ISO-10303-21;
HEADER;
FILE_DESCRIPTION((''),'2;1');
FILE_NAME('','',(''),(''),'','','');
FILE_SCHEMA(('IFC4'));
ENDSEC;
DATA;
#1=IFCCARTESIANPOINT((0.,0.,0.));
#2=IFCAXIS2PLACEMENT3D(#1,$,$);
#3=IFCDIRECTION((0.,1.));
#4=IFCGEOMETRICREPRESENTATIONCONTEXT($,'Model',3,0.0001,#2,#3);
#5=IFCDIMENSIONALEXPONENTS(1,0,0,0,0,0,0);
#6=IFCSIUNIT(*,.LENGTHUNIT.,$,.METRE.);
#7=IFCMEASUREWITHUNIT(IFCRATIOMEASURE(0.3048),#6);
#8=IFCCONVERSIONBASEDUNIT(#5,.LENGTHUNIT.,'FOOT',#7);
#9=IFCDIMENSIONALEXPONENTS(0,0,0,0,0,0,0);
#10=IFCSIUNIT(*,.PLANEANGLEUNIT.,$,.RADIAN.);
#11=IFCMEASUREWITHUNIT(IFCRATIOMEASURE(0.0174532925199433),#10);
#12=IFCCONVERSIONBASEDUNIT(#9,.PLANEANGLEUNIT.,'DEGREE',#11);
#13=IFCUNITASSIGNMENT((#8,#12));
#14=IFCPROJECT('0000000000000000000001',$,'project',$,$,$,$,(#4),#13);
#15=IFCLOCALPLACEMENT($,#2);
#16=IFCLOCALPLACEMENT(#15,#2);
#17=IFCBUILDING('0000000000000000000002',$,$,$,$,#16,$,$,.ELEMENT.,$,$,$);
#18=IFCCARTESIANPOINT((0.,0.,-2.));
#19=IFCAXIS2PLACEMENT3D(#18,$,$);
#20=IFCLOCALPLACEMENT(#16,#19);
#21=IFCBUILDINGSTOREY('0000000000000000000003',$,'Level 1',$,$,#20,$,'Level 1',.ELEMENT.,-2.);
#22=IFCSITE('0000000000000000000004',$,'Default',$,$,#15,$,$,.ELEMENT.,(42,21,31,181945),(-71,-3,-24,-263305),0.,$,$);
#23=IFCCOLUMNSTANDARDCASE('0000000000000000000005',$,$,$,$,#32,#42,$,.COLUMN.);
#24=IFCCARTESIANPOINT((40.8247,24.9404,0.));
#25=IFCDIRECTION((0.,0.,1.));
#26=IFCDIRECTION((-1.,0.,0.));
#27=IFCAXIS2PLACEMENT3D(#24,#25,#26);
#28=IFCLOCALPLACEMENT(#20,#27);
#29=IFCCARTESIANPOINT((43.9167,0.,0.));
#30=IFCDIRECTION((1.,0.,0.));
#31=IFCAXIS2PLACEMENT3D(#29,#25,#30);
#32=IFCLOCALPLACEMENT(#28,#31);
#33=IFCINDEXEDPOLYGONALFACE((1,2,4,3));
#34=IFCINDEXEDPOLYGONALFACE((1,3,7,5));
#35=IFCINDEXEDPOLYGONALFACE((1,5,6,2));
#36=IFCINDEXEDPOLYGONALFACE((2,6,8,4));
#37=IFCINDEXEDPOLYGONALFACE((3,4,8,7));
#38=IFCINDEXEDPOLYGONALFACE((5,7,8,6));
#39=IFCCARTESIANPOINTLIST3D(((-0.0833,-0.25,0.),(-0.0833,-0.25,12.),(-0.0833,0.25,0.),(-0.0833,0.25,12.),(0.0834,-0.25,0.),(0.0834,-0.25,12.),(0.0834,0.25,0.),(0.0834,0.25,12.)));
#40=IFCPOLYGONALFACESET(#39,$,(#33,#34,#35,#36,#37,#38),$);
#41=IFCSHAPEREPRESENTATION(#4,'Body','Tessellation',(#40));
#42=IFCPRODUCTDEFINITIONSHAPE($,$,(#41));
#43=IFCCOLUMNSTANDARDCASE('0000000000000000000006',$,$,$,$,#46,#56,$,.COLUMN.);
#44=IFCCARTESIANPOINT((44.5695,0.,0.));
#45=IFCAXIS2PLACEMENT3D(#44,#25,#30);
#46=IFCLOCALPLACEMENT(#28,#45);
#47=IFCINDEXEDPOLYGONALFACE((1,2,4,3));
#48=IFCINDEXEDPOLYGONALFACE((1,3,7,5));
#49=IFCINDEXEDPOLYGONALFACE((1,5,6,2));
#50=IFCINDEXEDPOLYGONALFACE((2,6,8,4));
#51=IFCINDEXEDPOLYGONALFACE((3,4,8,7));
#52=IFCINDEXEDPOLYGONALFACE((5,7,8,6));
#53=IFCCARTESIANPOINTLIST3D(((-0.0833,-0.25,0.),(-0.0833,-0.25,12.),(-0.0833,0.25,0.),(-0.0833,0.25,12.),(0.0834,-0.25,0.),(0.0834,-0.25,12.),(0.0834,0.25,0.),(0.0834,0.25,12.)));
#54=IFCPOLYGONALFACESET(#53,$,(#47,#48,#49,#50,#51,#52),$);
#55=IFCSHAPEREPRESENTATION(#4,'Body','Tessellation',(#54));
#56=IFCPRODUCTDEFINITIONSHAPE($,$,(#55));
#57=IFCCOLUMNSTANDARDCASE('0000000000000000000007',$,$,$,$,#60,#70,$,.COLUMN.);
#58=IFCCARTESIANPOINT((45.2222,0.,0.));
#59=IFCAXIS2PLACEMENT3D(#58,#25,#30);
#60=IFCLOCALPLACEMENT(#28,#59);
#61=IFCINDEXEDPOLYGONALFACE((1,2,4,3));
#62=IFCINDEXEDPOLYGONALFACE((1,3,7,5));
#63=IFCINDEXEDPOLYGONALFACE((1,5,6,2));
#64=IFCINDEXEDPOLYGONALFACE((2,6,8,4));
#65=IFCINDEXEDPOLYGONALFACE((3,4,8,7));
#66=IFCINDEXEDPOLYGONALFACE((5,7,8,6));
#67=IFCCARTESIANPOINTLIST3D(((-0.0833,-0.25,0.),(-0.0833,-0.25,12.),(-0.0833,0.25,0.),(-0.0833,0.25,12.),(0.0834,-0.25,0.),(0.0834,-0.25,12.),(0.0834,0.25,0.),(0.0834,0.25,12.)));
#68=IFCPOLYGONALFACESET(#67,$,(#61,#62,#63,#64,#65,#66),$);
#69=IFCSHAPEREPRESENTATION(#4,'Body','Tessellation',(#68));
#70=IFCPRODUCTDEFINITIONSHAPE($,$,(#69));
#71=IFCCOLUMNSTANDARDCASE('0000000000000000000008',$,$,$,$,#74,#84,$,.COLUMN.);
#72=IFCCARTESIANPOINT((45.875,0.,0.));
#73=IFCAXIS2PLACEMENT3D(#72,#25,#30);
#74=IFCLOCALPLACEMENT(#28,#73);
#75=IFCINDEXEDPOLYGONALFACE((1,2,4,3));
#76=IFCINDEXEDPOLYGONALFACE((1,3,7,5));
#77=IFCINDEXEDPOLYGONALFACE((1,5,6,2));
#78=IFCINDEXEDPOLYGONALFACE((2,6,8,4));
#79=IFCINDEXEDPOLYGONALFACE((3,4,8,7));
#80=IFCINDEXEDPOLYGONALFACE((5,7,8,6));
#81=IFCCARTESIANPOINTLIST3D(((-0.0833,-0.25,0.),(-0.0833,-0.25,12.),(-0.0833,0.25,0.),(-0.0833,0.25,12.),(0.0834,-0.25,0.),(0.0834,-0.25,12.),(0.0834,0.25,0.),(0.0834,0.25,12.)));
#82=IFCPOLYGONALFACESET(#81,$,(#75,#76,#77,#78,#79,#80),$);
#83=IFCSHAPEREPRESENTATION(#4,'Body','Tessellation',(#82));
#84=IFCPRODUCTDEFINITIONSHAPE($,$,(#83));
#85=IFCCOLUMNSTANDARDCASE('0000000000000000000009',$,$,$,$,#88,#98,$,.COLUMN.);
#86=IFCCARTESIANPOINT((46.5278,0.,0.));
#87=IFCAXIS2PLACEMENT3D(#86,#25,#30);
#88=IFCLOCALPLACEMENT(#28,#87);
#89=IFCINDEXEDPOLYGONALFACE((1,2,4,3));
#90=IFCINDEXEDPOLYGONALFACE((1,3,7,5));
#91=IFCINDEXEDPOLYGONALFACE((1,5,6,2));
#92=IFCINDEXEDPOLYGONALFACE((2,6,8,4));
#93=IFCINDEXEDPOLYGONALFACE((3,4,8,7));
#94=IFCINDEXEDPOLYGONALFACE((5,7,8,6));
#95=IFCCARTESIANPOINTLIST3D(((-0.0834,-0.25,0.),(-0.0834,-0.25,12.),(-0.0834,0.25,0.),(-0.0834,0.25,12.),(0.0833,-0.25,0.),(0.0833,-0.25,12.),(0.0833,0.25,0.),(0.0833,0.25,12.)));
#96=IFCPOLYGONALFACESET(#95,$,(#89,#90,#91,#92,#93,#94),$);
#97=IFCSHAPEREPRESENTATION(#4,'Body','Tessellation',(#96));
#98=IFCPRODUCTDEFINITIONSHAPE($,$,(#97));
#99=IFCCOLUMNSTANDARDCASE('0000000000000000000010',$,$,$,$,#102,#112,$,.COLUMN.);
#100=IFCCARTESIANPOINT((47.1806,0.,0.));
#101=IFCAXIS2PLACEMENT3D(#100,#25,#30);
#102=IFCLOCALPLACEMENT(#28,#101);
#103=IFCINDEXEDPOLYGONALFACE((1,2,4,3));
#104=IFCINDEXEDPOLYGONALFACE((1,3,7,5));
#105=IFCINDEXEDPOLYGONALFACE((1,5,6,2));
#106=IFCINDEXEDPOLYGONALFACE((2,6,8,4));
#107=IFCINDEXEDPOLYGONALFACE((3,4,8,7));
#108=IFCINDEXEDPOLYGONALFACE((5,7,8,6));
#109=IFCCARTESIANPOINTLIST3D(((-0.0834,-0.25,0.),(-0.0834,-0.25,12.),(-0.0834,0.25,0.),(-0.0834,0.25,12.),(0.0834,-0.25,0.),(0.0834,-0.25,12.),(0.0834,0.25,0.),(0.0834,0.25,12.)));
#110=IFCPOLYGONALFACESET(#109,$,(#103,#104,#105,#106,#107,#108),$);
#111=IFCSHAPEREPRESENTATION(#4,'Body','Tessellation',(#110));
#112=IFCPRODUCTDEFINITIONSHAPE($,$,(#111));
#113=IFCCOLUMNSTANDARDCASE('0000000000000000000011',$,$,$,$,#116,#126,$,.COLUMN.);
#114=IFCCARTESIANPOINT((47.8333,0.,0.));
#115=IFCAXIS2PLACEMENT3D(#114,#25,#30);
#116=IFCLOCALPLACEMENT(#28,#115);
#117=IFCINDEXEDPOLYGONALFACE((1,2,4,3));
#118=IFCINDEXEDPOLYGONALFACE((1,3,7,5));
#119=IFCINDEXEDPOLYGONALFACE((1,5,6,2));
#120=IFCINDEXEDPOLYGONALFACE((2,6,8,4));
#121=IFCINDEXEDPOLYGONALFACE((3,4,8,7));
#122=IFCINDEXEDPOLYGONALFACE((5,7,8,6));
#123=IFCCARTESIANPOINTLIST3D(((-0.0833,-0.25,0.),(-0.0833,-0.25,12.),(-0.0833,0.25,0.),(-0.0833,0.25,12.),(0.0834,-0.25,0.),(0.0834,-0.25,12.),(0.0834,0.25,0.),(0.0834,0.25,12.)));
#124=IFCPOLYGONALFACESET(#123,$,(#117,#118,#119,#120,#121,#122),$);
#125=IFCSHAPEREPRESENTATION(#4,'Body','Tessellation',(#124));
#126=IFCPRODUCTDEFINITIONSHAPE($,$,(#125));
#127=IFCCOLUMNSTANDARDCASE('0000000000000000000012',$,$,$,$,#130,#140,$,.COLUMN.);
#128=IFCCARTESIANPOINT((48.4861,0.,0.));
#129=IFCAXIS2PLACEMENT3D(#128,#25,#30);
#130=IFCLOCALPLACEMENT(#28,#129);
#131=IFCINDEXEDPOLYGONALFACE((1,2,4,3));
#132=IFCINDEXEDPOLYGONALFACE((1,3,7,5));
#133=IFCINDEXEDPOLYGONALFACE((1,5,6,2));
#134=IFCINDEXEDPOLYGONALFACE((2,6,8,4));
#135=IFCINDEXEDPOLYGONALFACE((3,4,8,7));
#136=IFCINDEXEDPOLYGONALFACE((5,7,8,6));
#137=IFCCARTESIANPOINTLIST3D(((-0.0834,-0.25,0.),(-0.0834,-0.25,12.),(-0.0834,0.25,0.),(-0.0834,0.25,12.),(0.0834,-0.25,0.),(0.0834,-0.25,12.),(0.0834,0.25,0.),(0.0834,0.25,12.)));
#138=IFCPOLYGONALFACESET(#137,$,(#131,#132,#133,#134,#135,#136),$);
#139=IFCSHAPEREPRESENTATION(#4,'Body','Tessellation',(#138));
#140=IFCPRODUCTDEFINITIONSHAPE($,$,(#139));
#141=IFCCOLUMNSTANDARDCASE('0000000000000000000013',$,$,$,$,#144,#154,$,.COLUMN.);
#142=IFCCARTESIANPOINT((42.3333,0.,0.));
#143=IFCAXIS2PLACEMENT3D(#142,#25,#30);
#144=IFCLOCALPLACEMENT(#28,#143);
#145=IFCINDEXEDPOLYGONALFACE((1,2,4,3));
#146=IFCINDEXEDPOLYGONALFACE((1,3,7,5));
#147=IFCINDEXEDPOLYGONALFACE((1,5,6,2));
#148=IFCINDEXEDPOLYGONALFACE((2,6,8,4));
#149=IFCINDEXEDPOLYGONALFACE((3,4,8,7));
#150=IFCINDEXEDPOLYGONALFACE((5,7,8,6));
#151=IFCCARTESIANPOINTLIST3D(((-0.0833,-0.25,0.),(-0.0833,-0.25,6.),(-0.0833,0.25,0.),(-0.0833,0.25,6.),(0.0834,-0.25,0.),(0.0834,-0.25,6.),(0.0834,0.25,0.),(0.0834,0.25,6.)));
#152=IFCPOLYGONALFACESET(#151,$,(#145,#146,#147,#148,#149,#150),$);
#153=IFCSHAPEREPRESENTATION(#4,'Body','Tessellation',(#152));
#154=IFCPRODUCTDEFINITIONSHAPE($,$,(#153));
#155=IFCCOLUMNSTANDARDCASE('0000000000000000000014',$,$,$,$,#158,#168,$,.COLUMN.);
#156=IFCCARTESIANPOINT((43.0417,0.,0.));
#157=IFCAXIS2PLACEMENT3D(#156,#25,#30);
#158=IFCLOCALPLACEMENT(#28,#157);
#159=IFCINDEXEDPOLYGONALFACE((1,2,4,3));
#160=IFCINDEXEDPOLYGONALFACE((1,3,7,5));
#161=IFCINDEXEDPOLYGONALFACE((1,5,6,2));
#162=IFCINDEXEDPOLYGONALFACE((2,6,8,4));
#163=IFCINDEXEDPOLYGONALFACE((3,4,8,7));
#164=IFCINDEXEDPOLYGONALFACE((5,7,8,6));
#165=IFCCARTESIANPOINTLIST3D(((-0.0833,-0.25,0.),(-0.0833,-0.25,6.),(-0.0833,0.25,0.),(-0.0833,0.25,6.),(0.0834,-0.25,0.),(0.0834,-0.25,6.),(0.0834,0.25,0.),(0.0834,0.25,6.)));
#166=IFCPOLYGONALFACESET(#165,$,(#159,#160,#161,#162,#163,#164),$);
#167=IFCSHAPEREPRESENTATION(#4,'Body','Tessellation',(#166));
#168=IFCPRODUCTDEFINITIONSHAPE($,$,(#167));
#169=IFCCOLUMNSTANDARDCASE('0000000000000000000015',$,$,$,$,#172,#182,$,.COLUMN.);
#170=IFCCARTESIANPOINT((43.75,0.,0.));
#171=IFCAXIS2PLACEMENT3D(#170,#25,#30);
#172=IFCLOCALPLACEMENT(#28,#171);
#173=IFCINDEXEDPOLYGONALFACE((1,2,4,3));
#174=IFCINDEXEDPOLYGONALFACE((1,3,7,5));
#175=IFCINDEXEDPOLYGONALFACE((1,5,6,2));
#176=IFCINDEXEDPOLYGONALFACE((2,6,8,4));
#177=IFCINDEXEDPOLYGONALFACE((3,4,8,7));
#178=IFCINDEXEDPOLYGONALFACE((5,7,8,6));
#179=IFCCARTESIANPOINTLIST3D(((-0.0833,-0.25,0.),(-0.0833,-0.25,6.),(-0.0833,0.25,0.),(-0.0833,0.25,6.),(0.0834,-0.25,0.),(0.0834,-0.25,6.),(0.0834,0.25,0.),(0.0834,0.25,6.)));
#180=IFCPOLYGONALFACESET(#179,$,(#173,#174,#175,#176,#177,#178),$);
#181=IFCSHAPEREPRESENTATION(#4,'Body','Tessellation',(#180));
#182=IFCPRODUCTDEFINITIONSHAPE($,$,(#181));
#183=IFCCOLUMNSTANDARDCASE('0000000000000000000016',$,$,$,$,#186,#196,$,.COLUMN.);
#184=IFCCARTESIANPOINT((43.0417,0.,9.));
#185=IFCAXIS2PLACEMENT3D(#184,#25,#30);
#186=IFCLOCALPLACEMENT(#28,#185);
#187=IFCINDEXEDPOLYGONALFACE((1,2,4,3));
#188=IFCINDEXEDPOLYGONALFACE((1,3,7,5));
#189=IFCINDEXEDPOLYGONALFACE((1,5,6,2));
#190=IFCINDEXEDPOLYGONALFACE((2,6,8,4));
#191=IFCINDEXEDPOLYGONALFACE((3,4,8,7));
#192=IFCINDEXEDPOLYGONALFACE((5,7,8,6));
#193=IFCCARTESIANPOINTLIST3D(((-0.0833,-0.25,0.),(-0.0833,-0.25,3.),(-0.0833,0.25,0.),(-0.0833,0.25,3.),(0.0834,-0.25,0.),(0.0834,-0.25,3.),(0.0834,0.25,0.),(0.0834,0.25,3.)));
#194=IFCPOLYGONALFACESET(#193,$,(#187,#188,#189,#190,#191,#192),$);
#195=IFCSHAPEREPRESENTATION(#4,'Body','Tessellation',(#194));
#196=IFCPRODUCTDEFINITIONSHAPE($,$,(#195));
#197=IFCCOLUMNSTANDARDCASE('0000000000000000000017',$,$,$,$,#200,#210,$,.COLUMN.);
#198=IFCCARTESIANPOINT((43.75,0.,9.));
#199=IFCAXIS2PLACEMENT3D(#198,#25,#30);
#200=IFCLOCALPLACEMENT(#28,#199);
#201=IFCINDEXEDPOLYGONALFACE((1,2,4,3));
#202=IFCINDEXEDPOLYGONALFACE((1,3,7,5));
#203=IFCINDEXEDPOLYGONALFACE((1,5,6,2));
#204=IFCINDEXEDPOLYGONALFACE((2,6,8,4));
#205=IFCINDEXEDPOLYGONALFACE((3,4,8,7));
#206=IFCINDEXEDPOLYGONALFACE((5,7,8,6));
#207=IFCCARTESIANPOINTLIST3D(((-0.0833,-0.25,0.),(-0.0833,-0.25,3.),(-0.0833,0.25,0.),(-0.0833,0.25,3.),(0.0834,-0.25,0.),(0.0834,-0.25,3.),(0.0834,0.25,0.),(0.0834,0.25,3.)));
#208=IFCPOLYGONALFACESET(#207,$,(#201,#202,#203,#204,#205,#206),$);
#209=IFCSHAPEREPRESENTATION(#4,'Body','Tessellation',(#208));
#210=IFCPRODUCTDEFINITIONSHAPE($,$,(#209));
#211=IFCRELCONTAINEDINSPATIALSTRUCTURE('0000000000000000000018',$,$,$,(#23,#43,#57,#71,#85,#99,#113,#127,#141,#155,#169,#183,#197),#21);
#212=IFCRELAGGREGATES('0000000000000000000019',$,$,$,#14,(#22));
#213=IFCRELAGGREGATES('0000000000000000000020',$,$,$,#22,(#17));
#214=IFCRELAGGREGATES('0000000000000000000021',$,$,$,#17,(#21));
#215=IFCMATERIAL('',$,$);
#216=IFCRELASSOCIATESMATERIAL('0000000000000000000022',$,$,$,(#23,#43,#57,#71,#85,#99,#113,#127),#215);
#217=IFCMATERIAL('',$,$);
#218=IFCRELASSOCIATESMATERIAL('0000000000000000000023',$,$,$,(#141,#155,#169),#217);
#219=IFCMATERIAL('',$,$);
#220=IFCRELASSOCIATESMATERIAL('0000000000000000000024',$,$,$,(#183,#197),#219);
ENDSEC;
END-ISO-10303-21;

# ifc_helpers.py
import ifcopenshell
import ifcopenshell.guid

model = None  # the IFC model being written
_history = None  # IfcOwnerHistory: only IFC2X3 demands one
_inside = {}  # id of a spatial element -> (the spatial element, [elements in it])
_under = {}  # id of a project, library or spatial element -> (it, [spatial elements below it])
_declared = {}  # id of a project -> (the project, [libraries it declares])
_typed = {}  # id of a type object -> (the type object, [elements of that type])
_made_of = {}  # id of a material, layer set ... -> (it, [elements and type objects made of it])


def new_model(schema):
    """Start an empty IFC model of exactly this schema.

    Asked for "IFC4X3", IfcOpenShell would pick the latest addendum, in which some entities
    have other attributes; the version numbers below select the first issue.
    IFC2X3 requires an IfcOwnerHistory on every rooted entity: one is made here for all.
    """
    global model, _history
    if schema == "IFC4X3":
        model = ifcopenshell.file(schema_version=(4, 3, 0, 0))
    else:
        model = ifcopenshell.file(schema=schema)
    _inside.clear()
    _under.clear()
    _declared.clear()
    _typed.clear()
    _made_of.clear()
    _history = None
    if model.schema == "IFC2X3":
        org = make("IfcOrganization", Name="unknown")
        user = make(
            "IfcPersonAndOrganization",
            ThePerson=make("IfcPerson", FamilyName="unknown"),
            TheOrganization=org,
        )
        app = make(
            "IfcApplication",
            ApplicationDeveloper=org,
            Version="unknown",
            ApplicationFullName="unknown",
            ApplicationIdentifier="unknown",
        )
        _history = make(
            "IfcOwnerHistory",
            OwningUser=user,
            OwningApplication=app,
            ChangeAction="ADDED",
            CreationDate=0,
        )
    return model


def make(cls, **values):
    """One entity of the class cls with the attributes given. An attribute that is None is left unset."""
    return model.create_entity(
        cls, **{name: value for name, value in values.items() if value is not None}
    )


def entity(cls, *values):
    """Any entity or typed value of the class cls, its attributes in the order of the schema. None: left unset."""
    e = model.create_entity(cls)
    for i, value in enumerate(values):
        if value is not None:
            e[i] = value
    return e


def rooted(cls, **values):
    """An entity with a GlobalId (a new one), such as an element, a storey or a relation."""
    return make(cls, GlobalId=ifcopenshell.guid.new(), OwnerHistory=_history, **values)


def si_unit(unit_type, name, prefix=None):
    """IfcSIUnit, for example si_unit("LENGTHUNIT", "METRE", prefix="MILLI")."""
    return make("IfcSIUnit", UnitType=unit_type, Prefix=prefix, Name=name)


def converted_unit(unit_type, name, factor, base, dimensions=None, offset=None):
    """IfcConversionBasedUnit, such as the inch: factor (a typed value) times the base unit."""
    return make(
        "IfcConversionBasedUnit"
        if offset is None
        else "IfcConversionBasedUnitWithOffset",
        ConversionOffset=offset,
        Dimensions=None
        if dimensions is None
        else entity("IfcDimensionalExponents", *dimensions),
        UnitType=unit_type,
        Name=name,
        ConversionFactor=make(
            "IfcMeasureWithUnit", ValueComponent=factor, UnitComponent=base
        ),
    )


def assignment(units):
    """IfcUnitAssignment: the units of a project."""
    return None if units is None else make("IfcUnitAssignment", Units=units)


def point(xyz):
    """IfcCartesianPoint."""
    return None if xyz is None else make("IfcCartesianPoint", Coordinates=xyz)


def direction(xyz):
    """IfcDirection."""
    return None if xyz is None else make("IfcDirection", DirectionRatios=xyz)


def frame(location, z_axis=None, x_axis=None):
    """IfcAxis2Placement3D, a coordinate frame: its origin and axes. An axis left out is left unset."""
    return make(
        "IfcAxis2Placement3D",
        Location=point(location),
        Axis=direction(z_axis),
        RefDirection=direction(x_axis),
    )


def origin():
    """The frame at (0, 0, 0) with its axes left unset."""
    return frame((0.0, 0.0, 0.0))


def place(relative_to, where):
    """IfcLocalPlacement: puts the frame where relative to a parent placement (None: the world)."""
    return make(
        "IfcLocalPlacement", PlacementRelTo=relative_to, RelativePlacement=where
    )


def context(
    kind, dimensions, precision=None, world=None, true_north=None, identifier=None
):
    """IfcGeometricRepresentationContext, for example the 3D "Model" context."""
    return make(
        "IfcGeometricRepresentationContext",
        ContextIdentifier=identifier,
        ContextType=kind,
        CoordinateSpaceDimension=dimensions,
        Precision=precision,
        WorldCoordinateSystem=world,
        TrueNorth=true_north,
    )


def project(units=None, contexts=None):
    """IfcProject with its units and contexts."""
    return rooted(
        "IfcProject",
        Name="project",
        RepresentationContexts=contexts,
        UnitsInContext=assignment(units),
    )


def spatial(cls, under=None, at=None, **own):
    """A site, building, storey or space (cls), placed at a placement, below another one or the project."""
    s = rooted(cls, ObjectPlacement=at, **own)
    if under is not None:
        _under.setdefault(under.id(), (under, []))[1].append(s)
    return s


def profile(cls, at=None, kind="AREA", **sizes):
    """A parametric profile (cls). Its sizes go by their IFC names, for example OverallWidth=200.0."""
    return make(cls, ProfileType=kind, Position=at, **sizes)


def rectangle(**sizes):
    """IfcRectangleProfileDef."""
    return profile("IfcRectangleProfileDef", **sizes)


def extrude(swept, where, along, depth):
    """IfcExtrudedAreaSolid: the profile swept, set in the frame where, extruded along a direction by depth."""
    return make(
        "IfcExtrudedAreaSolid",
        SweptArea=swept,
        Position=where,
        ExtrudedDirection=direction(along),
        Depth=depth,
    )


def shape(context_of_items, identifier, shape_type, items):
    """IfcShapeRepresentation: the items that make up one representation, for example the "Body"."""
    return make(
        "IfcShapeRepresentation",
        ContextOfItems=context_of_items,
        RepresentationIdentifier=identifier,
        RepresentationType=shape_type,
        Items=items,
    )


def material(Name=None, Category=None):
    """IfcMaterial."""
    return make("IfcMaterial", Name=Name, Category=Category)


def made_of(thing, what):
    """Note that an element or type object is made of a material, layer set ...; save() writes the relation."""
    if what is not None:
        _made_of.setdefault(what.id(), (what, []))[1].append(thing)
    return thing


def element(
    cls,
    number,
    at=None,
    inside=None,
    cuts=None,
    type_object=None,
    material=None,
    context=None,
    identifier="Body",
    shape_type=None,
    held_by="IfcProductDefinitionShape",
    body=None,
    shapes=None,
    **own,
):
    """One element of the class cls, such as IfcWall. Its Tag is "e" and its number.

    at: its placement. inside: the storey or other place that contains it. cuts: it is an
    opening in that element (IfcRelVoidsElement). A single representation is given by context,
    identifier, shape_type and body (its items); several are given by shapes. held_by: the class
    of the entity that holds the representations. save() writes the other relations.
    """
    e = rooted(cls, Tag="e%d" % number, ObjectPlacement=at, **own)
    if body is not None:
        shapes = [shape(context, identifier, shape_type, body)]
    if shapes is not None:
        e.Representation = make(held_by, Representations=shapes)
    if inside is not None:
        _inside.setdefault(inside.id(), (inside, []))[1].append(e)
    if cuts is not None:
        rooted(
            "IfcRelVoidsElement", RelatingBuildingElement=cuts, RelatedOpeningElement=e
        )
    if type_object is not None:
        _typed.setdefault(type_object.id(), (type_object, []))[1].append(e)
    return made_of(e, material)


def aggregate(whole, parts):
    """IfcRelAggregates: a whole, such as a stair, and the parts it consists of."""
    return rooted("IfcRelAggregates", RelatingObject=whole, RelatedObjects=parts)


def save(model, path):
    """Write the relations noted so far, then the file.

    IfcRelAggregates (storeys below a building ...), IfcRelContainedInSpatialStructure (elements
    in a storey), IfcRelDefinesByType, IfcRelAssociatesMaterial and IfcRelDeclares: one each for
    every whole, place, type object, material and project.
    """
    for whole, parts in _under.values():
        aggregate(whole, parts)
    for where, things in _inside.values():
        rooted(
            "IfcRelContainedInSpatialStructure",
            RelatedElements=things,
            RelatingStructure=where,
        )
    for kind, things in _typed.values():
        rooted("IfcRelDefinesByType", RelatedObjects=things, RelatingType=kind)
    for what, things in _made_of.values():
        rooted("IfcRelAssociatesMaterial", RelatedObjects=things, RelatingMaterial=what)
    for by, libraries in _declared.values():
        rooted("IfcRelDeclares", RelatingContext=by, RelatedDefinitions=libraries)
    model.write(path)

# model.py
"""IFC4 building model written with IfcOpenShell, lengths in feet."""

from ifc_helpers import new_model, entity, si_unit, converted_unit, direction, frame, origin, place, context, project, spatial, rectangle, extrude, material, element, save


model = new_model("IFC4")

# Units and contexts
model_context = context("Model", 3, precision=0.0001, world=origin(), true_north=direction((0.0, 1.0)))
ifc_project = project(units=[converted_unit("LENGTHUNIT", "FOOT", entity("IfcRatioMeasure", 0.3048), si_unit("LENGTHUNIT", "METRE"), dimensions=[1, 0, 0, 0, 0, 0, 0]), converted_unit("PLANEANGLEUNIT", "DEGREE", entity("IfcRatioMeasure", 0.0174532925199433), si_unit("PLANEANGLEUNIT", "RADIAN"), dimensions=[0, 0, 0, 0, 0, 0, 0])], contexts=[model_context])

# Site, building, storey
site_placement = place(None, origin())
site = spatial("IfcSite", under=ifc_project, at=site_placement, Name="Default", CompositionType="ELEMENT", RefLatitude=(42, 21, 31, 181945), RefLongitude=(-71, -3, -24, -263305), RefElevation=0.0)
building_placement = place(site_placement, origin())
building = spatial("IfcBuilding", under=site, at=building_placement, CompositionType="ELEMENT")
storey_placement = place(building_placement, frame((0.0, 0.0, -2.0)))
storey = spatial("IfcBuildingStorey", under=building, at=storey_placement, Name="Level 1", LongName="Level 1", CompositionType="ELEMENT", Elevation=-2.0)

# Columns
ifc_material_1 = material(Name="")
placement = place(storey_placement, frame((40.8247, 24.9404, 0.0), z_axis=(0.0, 0.0, 1.0), x_axis=(-1.0, 0.0, 0.0)))
for number, where, z_axis, x_axis in (
    (1, (43.9167, 0.0, 0.0), (0.0, 0.0, 1.0), (1.0, 0.0, 0.0)),
    (2, (44.5695, 0.0, 0.0), (0.0, 0.0, 1.0), (1.0, 0.0, 0.0)),
    (3, (45.2222, 0.0, 0.0), (0.0, 0.0, 1.0), (1.0, 0.0, 0.0)),
    (4, (45.875, 0.0, 0.0), (0.0, 0.0, 1.0), (1.0, 0.0, 0.0)),
    (5, (46.5278, 0.0, 0.0), (0.0, 0.0, 1.0), (1.0, 0.0, 0.0)),
    (6, (47.1806, 0.0, 0.0), (0.0, 0.0, 1.0), (1.0, 0.0, 0.0)),
    (7, (47.8333, 0.0, 0.0), (0.0, 0.0, 1.0), (1.0, 0.0, 0.0)),
    (8, (48.4861, 0.0, 0.0), (0.0, 0.0, 1.0), (1.0, 0.0, 0.0)),
):
    element("IfcColumnStandardCase", number, at=place(placement, frame(where, z_axis=z_axis, x_axis=x_axis)), inside=storey, material=ifc_material_1, PredefinedType="COLUMN", context=model_context, shape_type="SweptSolid", body=[
        extrude(rectangle(XDim=0.1667, YDim=0.5), origin(), (0.0, 0.0, 1.0), 12.0),
    ])
ifc_material_2 = material(Name="")
for number, where, z_axis, x_axis in (
    (9, (42.3333, 0.0, 0.0), (0.0, 0.0, 1.0), (1.0, 0.0, 0.0)),
    (10, (43.0417, 0.0, 0.0), (0.0, 0.0, 1.0), (1.0, 0.0, 0.0)),
    (11, (43.75, 0.0, 0.0), (0.0, 0.0, 1.0), (1.0, 0.0, 0.0)),
):
    element("IfcColumnStandardCase", number, at=place(placement, frame(where, z_axis=z_axis, x_axis=x_axis)), inside=storey, material=ifc_material_2, PredefinedType="COLUMN", context=model_context, shape_type="SweptSolid", body=[
        extrude(rectangle(XDim=0.1667, YDim=0.5), origin(), (0.0, 0.0, 1.0), 6.0),
    ])
ifc_material_3 = material(Name="")
for number, where, z_axis, x_axis in (
    (12, (43.0417, 0.0, 9.0), (0.0, 0.0, 1.0), (1.0, 0.0, 0.0)),
    (13, (43.75, 0.0, 9.0), (0.0, 0.0, 1.0), (1.0, 0.0, 0.0)),
):
    element("IfcColumnStandardCase", number, at=place(placement, frame(where, z_axis=z_axis, x_axis=x_axis)), inside=storey, material=ifc_material_3, PredefinedType="COLUMN", context=model_context, shape_type="SweptSolid", body=[
        extrude(rectangle(XDim=0.1667, YDim=0.5), origin(), (0.0, 0.0, 1.0), 3.0),
    ])

save(model, "model.ifc")
